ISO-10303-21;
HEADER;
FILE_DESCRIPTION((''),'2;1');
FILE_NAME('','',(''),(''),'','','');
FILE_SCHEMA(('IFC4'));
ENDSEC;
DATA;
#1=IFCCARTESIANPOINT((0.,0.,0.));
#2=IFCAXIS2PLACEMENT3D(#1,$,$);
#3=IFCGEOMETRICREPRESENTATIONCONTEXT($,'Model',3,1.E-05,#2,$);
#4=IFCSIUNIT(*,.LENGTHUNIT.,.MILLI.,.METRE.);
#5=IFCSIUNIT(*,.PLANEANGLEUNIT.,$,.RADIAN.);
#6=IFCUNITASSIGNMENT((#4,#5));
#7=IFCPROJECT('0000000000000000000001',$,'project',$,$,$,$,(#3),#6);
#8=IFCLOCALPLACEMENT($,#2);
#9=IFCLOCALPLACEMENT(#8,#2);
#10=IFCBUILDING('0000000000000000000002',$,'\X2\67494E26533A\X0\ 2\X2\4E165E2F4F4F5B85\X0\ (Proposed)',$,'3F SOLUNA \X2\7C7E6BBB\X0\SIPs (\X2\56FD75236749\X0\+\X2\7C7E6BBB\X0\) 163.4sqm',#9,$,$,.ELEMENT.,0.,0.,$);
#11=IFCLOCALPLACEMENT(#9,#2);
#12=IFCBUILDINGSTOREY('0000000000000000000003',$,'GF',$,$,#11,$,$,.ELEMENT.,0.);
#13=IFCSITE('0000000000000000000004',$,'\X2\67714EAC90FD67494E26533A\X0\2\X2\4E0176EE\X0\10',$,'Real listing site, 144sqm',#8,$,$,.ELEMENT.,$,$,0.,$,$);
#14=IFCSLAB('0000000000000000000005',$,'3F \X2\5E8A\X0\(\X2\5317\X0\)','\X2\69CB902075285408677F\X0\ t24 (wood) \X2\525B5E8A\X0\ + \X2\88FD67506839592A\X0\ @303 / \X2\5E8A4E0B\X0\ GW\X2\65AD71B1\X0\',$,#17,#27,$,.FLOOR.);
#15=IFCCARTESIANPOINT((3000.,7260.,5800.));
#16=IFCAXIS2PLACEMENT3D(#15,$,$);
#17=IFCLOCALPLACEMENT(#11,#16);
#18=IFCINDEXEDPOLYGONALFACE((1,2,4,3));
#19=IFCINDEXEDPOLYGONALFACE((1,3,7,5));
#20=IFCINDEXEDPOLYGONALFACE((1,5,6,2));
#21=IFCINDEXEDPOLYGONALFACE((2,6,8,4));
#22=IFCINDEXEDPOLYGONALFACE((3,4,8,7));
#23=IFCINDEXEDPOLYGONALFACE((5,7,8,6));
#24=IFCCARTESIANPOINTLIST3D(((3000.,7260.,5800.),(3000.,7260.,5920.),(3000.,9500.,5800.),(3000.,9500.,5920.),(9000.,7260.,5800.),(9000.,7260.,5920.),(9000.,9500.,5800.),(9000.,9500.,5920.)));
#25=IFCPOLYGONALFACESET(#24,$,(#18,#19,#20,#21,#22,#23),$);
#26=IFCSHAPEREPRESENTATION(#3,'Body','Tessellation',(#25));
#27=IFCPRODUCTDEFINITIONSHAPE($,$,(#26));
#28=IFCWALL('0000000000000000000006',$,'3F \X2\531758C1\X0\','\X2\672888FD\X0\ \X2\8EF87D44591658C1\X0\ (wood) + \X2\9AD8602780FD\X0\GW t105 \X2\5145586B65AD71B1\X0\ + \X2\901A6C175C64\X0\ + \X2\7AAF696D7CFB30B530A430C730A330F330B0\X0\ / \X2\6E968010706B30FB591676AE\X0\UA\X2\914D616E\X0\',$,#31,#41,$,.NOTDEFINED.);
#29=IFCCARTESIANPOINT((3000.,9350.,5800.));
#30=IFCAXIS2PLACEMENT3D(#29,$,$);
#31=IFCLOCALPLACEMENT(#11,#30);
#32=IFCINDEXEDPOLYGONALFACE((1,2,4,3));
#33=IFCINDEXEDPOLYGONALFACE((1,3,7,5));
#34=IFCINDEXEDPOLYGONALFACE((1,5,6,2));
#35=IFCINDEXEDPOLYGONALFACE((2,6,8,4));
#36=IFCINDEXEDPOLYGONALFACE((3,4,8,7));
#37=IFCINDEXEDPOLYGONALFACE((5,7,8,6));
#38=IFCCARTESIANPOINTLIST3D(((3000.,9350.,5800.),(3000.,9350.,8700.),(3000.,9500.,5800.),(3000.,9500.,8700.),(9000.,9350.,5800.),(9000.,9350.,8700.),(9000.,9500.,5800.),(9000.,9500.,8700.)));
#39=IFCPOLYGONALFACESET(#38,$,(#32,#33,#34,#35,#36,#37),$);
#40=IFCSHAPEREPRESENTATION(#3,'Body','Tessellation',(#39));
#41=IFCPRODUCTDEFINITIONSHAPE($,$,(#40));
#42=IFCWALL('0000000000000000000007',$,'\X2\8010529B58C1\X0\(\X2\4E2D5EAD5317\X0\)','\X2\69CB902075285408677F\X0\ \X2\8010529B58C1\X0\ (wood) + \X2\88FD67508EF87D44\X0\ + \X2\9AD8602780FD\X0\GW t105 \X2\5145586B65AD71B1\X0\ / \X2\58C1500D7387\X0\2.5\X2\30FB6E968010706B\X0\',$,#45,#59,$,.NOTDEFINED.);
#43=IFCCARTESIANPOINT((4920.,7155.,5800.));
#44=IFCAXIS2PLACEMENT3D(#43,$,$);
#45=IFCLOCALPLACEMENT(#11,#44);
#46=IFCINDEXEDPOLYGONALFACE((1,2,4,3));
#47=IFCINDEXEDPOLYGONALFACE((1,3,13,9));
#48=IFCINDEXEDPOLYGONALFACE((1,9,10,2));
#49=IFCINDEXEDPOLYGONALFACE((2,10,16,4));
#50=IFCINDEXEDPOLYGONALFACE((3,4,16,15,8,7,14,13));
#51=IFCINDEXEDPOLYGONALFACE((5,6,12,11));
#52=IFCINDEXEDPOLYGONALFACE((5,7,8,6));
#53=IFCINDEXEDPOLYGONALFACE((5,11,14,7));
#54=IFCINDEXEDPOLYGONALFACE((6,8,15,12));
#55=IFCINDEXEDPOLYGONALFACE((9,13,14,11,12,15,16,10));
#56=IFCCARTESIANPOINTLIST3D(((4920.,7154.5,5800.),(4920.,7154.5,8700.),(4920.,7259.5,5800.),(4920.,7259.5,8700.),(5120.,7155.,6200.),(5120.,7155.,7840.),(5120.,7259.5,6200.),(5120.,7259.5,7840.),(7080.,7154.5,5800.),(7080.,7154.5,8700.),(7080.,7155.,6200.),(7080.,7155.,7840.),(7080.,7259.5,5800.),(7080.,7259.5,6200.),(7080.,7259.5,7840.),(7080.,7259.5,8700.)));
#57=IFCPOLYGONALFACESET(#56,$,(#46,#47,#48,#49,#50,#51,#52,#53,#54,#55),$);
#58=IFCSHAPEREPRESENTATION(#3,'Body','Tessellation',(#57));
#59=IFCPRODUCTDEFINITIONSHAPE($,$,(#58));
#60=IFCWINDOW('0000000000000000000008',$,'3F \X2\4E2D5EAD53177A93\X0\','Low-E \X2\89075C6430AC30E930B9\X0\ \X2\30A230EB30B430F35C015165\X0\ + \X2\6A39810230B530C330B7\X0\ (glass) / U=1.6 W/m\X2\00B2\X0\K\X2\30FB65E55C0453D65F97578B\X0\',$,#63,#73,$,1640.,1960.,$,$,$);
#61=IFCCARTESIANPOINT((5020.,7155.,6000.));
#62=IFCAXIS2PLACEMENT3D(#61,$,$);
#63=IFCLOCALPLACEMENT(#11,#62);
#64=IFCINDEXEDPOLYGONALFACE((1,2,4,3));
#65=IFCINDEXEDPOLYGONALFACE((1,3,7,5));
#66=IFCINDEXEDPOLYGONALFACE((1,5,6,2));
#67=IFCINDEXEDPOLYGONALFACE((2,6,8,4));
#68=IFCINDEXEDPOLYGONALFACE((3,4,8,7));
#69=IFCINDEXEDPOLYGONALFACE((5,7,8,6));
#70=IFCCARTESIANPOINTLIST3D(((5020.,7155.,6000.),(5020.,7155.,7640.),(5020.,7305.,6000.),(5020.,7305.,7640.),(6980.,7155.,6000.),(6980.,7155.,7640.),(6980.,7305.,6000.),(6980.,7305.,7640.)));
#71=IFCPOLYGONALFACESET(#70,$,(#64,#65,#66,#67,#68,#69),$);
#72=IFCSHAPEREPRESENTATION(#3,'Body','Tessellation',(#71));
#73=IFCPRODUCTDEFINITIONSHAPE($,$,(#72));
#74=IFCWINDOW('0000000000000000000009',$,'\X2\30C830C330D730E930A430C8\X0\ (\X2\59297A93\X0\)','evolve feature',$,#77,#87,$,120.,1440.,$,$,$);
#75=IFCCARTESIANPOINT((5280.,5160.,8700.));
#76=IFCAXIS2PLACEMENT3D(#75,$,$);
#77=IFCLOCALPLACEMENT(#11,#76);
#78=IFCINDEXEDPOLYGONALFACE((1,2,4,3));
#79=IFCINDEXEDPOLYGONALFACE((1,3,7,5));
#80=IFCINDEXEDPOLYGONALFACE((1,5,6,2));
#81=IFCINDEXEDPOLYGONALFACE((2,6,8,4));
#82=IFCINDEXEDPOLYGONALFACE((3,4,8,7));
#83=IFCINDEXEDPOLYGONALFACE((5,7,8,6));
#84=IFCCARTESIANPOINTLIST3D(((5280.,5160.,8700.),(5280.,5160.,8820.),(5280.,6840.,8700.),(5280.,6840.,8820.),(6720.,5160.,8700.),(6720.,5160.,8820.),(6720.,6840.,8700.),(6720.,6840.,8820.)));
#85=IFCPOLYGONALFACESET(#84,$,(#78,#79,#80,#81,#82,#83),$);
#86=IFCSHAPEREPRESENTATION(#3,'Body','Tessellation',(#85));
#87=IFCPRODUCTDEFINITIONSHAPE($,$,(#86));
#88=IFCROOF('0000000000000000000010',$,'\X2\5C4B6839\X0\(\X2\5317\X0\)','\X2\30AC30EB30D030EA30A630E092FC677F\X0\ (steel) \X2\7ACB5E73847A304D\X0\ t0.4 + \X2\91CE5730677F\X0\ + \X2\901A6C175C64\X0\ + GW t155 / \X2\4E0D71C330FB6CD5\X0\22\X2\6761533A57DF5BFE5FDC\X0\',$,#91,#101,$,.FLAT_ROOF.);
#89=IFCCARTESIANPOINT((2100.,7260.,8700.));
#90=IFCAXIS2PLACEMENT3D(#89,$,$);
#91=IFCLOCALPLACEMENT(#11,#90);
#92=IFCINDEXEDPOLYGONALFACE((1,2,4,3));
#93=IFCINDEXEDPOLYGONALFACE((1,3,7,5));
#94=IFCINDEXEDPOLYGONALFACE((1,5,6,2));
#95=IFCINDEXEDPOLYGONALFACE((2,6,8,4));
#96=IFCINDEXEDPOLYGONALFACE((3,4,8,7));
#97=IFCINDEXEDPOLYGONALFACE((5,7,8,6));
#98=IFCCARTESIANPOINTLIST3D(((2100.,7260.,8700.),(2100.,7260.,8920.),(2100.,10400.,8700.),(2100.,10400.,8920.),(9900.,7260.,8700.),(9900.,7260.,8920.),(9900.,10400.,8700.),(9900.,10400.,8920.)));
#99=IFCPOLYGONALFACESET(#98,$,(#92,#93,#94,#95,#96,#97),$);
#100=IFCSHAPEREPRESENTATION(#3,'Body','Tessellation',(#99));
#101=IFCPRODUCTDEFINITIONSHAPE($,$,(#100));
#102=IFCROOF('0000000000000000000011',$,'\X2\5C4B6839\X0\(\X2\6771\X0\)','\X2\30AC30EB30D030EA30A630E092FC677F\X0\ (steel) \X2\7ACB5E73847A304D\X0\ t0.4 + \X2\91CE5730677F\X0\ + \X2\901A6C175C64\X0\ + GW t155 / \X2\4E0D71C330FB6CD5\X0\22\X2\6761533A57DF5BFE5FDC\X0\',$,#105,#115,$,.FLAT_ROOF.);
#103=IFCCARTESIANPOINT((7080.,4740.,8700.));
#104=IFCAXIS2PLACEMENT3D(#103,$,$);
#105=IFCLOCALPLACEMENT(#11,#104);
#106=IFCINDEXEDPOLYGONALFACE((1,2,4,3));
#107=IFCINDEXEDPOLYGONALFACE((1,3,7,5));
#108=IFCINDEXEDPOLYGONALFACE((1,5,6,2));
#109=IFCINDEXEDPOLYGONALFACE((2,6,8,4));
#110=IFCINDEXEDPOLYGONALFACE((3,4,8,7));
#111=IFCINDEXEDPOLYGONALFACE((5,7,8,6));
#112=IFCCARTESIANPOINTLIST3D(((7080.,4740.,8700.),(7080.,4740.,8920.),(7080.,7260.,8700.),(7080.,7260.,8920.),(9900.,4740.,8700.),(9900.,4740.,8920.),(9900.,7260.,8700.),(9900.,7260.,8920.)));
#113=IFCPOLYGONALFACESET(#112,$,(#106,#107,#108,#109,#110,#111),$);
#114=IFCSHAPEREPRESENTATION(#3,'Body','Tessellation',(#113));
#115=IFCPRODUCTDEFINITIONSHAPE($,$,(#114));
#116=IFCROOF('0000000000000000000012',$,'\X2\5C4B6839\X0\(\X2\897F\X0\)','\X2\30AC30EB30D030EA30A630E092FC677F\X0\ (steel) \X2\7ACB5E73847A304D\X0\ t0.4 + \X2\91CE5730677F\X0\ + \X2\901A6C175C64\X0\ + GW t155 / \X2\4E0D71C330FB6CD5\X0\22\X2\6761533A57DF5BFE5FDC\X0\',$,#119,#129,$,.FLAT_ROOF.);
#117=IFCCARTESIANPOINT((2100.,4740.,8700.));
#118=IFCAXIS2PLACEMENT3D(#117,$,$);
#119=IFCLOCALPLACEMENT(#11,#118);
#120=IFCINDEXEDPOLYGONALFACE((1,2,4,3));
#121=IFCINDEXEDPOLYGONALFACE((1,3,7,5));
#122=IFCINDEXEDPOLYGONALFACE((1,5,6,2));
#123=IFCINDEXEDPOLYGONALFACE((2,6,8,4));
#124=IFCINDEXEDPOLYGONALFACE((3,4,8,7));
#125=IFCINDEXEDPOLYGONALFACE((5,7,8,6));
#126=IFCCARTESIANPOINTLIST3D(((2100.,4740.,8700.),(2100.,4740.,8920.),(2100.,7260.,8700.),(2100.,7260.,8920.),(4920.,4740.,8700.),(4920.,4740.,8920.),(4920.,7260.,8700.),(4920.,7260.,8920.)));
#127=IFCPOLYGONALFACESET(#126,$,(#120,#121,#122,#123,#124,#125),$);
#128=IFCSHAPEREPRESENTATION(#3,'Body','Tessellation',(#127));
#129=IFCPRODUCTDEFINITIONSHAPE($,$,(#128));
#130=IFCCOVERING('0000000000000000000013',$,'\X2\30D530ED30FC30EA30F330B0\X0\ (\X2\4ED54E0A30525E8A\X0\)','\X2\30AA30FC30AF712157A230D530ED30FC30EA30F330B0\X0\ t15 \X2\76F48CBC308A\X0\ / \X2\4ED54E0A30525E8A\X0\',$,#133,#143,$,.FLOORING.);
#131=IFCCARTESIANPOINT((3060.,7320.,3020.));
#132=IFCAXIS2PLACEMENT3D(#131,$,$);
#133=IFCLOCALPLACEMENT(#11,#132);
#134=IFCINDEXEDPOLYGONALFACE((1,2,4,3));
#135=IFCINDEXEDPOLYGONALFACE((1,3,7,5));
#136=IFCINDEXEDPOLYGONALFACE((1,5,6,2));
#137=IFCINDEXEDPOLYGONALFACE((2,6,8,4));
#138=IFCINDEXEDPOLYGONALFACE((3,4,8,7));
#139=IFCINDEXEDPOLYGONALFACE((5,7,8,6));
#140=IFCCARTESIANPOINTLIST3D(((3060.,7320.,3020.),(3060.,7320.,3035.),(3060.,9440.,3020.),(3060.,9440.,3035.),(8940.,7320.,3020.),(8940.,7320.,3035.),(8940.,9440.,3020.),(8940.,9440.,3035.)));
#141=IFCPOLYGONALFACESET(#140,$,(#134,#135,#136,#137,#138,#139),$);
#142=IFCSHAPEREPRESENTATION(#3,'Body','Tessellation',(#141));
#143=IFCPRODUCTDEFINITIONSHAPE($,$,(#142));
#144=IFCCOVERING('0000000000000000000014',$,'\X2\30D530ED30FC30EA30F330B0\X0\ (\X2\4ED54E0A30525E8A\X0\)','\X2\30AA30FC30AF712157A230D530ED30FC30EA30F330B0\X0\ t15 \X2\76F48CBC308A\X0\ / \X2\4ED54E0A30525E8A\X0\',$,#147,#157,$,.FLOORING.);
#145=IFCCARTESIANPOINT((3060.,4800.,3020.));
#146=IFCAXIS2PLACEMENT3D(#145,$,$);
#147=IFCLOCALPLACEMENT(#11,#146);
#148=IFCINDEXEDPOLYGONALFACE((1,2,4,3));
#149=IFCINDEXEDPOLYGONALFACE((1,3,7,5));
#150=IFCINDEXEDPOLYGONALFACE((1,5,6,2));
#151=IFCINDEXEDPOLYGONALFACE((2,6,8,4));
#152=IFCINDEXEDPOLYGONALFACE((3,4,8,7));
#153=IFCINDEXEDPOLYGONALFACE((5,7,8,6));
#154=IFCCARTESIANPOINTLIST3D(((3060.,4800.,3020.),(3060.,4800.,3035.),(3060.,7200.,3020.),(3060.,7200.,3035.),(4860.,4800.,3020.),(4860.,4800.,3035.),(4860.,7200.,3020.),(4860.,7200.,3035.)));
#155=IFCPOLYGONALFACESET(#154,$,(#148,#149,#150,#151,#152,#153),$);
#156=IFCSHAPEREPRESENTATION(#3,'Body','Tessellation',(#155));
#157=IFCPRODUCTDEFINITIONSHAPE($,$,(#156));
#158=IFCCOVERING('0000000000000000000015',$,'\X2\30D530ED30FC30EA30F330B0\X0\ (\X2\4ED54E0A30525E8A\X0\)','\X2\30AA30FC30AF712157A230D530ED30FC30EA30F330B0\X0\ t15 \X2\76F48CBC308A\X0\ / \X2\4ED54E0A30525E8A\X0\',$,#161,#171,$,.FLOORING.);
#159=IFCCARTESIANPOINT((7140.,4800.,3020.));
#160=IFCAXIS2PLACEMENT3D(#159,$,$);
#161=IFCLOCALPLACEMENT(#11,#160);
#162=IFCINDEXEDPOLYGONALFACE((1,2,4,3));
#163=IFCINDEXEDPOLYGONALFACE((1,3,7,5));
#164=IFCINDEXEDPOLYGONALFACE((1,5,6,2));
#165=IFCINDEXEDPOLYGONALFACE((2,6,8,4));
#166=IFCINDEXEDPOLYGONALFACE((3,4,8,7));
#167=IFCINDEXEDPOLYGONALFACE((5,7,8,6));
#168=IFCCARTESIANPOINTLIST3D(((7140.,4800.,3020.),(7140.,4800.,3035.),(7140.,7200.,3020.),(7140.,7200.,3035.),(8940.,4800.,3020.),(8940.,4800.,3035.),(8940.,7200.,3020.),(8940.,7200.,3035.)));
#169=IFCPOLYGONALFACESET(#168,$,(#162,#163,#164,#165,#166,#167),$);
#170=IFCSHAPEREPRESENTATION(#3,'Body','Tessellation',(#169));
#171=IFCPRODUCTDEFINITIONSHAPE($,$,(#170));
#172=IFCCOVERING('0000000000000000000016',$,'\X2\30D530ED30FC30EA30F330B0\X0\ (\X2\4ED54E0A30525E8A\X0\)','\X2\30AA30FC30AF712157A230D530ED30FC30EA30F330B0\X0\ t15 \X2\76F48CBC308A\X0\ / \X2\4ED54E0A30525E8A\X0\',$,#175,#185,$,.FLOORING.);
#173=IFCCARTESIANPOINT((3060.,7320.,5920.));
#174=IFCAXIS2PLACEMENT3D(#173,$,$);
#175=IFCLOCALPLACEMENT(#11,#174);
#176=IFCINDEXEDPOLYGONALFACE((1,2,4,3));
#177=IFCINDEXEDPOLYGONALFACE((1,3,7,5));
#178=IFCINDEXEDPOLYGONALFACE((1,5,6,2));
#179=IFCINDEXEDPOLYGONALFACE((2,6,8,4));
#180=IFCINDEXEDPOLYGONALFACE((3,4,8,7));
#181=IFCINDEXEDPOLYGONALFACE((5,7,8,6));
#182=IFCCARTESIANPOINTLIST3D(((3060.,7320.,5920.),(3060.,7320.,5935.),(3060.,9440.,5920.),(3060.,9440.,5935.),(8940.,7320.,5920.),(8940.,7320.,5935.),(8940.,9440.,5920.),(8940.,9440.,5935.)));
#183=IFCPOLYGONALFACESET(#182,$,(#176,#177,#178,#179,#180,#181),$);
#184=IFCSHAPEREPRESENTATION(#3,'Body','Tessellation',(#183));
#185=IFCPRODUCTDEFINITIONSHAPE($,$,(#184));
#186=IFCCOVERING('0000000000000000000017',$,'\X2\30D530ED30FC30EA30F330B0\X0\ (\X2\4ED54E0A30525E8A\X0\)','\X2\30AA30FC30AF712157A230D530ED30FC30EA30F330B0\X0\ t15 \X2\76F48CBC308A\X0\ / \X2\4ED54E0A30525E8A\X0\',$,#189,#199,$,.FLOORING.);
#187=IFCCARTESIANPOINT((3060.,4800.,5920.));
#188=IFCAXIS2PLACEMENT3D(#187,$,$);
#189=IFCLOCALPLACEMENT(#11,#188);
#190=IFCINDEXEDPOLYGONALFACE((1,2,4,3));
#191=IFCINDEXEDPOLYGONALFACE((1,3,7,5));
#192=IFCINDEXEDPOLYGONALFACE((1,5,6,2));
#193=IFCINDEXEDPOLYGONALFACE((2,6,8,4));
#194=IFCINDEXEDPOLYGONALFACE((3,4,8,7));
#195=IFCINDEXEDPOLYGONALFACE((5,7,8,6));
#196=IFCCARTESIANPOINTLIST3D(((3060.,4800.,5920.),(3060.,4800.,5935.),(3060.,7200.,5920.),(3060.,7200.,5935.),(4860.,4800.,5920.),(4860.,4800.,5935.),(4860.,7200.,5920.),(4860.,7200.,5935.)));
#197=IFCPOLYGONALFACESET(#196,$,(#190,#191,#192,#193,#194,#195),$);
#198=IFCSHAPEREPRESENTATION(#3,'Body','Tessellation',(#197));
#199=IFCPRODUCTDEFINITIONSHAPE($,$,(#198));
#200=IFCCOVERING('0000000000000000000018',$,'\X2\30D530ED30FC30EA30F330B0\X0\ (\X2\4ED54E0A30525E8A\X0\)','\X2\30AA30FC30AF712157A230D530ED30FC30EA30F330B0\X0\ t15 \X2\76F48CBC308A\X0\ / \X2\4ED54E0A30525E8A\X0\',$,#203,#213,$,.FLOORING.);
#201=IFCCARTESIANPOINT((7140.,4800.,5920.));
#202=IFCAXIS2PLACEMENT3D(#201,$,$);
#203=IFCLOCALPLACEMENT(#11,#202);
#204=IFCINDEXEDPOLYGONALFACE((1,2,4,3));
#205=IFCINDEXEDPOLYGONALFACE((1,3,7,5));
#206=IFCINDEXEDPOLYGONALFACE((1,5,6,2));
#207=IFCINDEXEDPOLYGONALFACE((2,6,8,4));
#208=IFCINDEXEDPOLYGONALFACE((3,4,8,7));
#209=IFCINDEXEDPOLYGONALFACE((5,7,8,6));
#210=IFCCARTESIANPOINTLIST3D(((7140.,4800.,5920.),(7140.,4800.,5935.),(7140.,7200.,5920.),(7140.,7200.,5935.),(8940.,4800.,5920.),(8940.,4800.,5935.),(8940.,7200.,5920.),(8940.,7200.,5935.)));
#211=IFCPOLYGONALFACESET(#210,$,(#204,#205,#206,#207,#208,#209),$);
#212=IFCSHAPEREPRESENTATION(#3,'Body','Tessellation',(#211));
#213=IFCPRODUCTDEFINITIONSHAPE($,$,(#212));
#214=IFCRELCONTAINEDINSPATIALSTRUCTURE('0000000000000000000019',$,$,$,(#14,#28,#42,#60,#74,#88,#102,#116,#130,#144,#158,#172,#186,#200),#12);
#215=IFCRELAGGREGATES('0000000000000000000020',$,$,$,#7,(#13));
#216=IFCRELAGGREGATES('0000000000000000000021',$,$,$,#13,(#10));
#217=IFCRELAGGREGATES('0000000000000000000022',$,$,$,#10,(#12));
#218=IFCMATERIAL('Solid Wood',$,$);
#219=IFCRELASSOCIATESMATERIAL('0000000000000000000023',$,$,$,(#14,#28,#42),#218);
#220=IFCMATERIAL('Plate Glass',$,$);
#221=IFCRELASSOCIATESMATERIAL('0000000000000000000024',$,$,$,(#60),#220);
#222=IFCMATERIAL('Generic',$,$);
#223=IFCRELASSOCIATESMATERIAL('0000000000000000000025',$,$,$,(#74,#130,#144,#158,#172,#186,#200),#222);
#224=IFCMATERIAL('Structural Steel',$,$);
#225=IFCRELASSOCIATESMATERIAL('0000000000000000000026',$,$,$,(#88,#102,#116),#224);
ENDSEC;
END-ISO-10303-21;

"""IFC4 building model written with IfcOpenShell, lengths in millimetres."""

from ifc_helpers import new_model, si_unit, frame, frame_2d, origin, place, context, project, spatial, rectangle, extrude, material, element, fill, save


model = new_model("IFC4")

# Units and contexts
model_context = context("Model", 3, precision=1e-05, world=origin())
ifc_project = project(units=[si_unit("LENGTHUNIT", "METRE", prefix="MILLI"), si_unit("PLANEANGLEUNIT", "RADIAN")], contexts=[model_context])

# Site, building, storey
site_placement = place(None, origin())
site = spatial("IfcSite", under=ifc_project, at=site_placement, Name="東京都杉並区2丁目10", ObjectType="Real listing site, 144sqm", CompositionType="ELEMENT", RefElevation=0.0)
building_placement = place(site_placement, origin())
building = spatial("IfcBuilding", under=site, at=building_placement, Name="杉並区 2世帯住宅 (Proposed)", ObjectType="3F SOLUNA 籾殻SIPs (国産杉+籾殻) 163.4sqm", CompositionType="ELEMENT", ElevationOfRefHeight=0.0, ElevationOfTerrain=0.0)
storey_placement = place(building_placement, origin())
storey = spatial("IfcBuildingStorey", under=building, at=storey_placement, Name="GF", CompositionType="ELEMENT", Elevation=0.0)

# Slab
ifc_material_1 = material(Name="Solid Wood")
slab_placement = place(storey_placement, frame((3000.0, 7260.0, 5800.0)))
element("IfcSlab", 1, at=slab_placement, inside=storey, material=ifc_material_1, Name="3F 床(北)", Description="構造用合板 t24 (wood) 剛床 + 製材根太 @303 / 床下 GW断熱", PredefinedType="FLOOR", context=model_context, shape_type="SweptSolid", body=[
    extrude(rectangle(XDim=6000.0, YDim=2240.0, at=frame_2d((3000.0, 1120.0))), frame((3000.0, 7260.0, 5800.0)), (0.0, 0.0, 1.0), 120.0),
])

# Wall
wall_1_placement = place(storey_placement, frame((3000.0, 9350.0, 5800.0)))
element("IfcWall", 2, at=wall_1_placement, inside=storey, material=ifc_material_1, Name="3F 北壁", Description="木製 軸組外壁 (wood) + 高性能GW t105 充填断熱 + 通気層 + 窯業系サイディング / 準耐火・外皮UA配慮", PredefinedType="NOTDEFINED", context=model_context, shape_type="SweptSolid", body=[
    extrude(rectangle(XDim=6000.0, YDim=150.0, at=frame_2d((3000.0, 75.0))), frame((3000.0, 9350.0, 5800.0)), (0.0, 0.0, 1.0), 2900.0),
])

# Wall, opening, window
wall_2_placement = place(storey_placement, frame((4920.0, 7155.0, 5800.0)))
wall_2 = element("IfcWall", 3, at=wall_2_placement, inside=storey, material=ifc_material_1, Name="耐力壁(中庭北)", Description="構造用合板 耐力壁 (wood) + 製材軸組 + 高性能GW t105 充填断熱 / 壁倍率2.5・準耐火", PredefinedType="NOTDEFINED", context=model_context, shape_type="SweptSolid", body=[
    extrude(rectangle(XDim=2160.0, YDim=105.0, at=frame_2d((1080.0, 52.0))), frame((4920.0, 7155.0, 5800.0)), (0.0, 0.0, 1.0), 2900.0),
])
opening_placement = place(storey_placement, frame((5020.0, 7155.0, 6000.0)))
opening = element("IfcOpeningElement", 4, at=opening_placement, cuts=wall_2, PredefinedType="NOTDEFINED", context=model_context, shape_type="SweptSolid", body=[
    extrude(rectangle(XDim=1960.0, YDim=150.0, at=frame_2d((980.0, 75.0))), frame((5020.0, 7155.0, 6000.0)), (0.0, 0.0, 1.0), 1640.0),
])
ifc_material_2 = material(Name="Plate Glass")
window_1_placement = place(storey_placement, frame((5020.0, 7155.0, 6000.0)))
window_1 = element("IfcWindow", 5, at=window_1_placement, inside=storey, material=ifc_material_2, Name="3F 中庭北窓", Description="Low-E 複層ガラス アルゴン封入 + 樹脂サッシ (glass) / U=1.6 W/m²K・日射取得型", OverallHeight=1640.0, OverallWidth=1960.0, context=model_context, shape_type="SweptSolid", body=[
    extrude(rectangle(XDim=1960.0, YDim=150.0, at=frame_2d((980.0, 75.0))), frame((5020.0, 7155.0, 6000.0)), (0.0, 0.0, 1.0), 1640.0),
])
fill(opening, window_1)

# Window
ifc_material_3 = material(Name="Generic")
window_2_placement = place(storey_placement, frame((5280.0, 5160.0, 8700.0)))
element("IfcWindow", 6, at=window_2_placement, inside=storey, material=ifc_material_3, Name="トップライト (天窓)", Description="evolve feature", OverallHeight=120.0, OverallWidth=1440.0, context=model_context, shape_type="SweptSolid", body=[
    extrude(rectangle(XDim=1440.0, YDim=1680.0, at=frame_2d((720.0, 840.0))), frame((5280.0, 5160.0, 8700.0)), (0.0, 0.0, 1.0), 120.0),
])

# Roofs
ifc_material_4 = material(Name="Structural Steel")
roof_1_placement = place(storey_placement, frame((2100.0, 7260.0, 8700.0)))
element("IfcRoof", 7, at=roof_1_placement, inside=storey, material=ifc_material_4, Name="屋根(北)", Description="ガルバリウム鋼板 (steel) 立平葺き t0.4 + 野地板 + 通気層 + GW t155 / 不燃・法22条区域対応", PredefinedType="FLAT_ROOF", context=model_context, shape_type="SweptSolid", body=[
    extrude(rectangle(XDim=7800.0, YDim=3140.0, at=frame_2d((3900.0, 1570.0))), frame((2100.0, 7260.0, 8700.0)), (0.0, 0.0, 1.0), 220.0),
])
roof_2_placement = place(storey_placement, frame((7080.0, 4740.0, 8700.0)))
element("IfcRoof", 8, at=roof_2_placement, inside=storey, material=ifc_material_4, Name="屋根(東)", Description="ガルバリウム鋼板 (steel) 立平葺き t0.4 + 野地板 + 通気層 + GW t155 / 不燃・法22条区域対応", PredefinedType="FLAT_ROOF", context=model_context, shape_type="SweptSolid", body=[
    extrude(rectangle(XDim=2820.0, YDim=2520.0, at=frame_2d((1410.0, 1260.0))), frame((7080.0, 4740.0, 8700.0)), (0.0, 0.0, 1.0), 220.0),
])
roof_3_placement = place(storey_placement, frame((2100.0, 4740.0, 8700.0)))
element("IfcRoof", 9, at=roof_3_placement, inside=storey, material=ifc_material_4, Name="屋根(西)", Description="ガルバリウム鋼板 (steel) 立平葺き t0.4 + 野地板 + 通気層 + GW t155 / 不燃・法22条区域対応", PredefinedType="FLAT_ROOF", context=model_context, shape_type="SweptSolid", body=[
    extrude(rectangle(XDim=2820.0, YDim=2520.0, at=frame_2d((1410.0, 1260.0))), frame((2100.0, 4740.0, 8700.0)), (0.0, 0.0, 1.0), 220.0),
])

# Coverings
covering_1_placement = place(storey_placement, frame((3060.0, 7320.0, 3020.0)))
element("IfcCovering", 10, at=covering_1_placement, inside=storey, material=ifc_material_3, Name="フローリング (仕上げ床)", Description="オーク無垢フローリング t15 直貼り / 仕上げ床", PredefinedType="FLOORING", context=model_context, shape_type="SweptSolid", body=[
    extrude(rectangle(XDim=5880.0, YDim=2120.0, at=frame_2d((2940.0, 1060.0))), frame((3060.0, 7320.0, 3020.0)), (0.0, 0.0, 1.0), 15.0),
])
covering_2_placement = place(storey_placement, frame((3060.0, 4800.0, 3020.0)))
element("IfcCovering", 11, at=covering_2_placement, inside=storey, material=ifc_material_3, Name="フローリング (仕上げ床)", Description="オーク無垢フローリング t15 直貼り / 仕上げ床", PredefinedType="FLOORING", context=model_context, shape_type="SweptSolid", body=[
    extrude(rectangle(XDim=1800.0, YDim=2400.0, at=frame_2d((900.0, 1200.0))), frame((3060.0, 4800.0, 3020.0)), (0.0, 0.0, 1.0), 15.0),
])
covering_3_placement = place(storey_placement, frame((7140.0, 4800.0, 3020.0)))
element("IfcCovering", 12, at=covering_3_placement, inside=storey, material=ifc_material_3, Name="フローリング (仕上げ床)", Description="オーク無垢フローリング t15 直貼り / 仕上げ床", PredefinedType="FLOORING", context=model_context, shape_type="SweptSolid", body=[
    extrude(rectangle(XDim=1800.0, YDim=2400.0, at=frame_2d((900.0, 1200.0))), frame((7140.0, 4800.0, 3020.0)), (0.0, 0.0, 1.0), 15.0),
])
covering_4_placement = place(storey_placement, frame((3060.0, 7320.0, 5920.0)))
element("IfcCovering", 13, at=covering_4_placement, inside=storey, material=ifc_material_3, Name="フローリング (仕上げ床)", Description="オーク無垢フローリング t15 直貼り / 仕上げ床", PredefinedType="FLOORING", context=model_context, shape_type="SweptSolid", body=[
    extrude(rectangle(XDim=5880.0, YDim=2120.0, at=frame_2d((2940.0, 1060.0))), frame((3060.0, 7320.0, 5920.0)), (0.0, 0.0, 1.0), 15.0),
])
covering_5_placement = place(storey_placement, frame((3060.0, 4800.0, 5920.0)))
element("IfcCovering", 14, at=covering_5_placement, inside=storey, material=ifc_material_3, Name="フローリング (仕上げ床)", Description="オーク無垢フローリング t15 直貼り / 仕上げ床", PredefinedType="FLOORING", context=model_context, shape_type="SweptSolid", body=[
    extrude(rectangle(XDim=1800.0, YDim=2400.0, at=frame_2d((900.0, 1200.0))), frame((3060.0, 4800.0, 5920.0)), (0.0, 0.0, 1.0), 15.0),
])
covering_6_placement = place(storey_placement, frame((7140.0, 4800.0, 5920.0)))
element("IfcCovering", 15, at=covering_6_placement, inside=storey, material=ifc_material_3, Name="フローリング (仕上げ床)", Description="オーク無垢フローリング t15 直貼り / 仕上げ床", PredefinedType="FLOORING", context=model_context, shape_type="SweptSolid", body=[
    extrude(rectangle(XDim=1800.0, YDim=2400.0, at=frame_2d((900.0, 1200.0))), frame((7140.0, 4800.0, 5920.0)), (0.0, 0.0, 1.0), 15.0),
])

save(model, "model.ifc")
